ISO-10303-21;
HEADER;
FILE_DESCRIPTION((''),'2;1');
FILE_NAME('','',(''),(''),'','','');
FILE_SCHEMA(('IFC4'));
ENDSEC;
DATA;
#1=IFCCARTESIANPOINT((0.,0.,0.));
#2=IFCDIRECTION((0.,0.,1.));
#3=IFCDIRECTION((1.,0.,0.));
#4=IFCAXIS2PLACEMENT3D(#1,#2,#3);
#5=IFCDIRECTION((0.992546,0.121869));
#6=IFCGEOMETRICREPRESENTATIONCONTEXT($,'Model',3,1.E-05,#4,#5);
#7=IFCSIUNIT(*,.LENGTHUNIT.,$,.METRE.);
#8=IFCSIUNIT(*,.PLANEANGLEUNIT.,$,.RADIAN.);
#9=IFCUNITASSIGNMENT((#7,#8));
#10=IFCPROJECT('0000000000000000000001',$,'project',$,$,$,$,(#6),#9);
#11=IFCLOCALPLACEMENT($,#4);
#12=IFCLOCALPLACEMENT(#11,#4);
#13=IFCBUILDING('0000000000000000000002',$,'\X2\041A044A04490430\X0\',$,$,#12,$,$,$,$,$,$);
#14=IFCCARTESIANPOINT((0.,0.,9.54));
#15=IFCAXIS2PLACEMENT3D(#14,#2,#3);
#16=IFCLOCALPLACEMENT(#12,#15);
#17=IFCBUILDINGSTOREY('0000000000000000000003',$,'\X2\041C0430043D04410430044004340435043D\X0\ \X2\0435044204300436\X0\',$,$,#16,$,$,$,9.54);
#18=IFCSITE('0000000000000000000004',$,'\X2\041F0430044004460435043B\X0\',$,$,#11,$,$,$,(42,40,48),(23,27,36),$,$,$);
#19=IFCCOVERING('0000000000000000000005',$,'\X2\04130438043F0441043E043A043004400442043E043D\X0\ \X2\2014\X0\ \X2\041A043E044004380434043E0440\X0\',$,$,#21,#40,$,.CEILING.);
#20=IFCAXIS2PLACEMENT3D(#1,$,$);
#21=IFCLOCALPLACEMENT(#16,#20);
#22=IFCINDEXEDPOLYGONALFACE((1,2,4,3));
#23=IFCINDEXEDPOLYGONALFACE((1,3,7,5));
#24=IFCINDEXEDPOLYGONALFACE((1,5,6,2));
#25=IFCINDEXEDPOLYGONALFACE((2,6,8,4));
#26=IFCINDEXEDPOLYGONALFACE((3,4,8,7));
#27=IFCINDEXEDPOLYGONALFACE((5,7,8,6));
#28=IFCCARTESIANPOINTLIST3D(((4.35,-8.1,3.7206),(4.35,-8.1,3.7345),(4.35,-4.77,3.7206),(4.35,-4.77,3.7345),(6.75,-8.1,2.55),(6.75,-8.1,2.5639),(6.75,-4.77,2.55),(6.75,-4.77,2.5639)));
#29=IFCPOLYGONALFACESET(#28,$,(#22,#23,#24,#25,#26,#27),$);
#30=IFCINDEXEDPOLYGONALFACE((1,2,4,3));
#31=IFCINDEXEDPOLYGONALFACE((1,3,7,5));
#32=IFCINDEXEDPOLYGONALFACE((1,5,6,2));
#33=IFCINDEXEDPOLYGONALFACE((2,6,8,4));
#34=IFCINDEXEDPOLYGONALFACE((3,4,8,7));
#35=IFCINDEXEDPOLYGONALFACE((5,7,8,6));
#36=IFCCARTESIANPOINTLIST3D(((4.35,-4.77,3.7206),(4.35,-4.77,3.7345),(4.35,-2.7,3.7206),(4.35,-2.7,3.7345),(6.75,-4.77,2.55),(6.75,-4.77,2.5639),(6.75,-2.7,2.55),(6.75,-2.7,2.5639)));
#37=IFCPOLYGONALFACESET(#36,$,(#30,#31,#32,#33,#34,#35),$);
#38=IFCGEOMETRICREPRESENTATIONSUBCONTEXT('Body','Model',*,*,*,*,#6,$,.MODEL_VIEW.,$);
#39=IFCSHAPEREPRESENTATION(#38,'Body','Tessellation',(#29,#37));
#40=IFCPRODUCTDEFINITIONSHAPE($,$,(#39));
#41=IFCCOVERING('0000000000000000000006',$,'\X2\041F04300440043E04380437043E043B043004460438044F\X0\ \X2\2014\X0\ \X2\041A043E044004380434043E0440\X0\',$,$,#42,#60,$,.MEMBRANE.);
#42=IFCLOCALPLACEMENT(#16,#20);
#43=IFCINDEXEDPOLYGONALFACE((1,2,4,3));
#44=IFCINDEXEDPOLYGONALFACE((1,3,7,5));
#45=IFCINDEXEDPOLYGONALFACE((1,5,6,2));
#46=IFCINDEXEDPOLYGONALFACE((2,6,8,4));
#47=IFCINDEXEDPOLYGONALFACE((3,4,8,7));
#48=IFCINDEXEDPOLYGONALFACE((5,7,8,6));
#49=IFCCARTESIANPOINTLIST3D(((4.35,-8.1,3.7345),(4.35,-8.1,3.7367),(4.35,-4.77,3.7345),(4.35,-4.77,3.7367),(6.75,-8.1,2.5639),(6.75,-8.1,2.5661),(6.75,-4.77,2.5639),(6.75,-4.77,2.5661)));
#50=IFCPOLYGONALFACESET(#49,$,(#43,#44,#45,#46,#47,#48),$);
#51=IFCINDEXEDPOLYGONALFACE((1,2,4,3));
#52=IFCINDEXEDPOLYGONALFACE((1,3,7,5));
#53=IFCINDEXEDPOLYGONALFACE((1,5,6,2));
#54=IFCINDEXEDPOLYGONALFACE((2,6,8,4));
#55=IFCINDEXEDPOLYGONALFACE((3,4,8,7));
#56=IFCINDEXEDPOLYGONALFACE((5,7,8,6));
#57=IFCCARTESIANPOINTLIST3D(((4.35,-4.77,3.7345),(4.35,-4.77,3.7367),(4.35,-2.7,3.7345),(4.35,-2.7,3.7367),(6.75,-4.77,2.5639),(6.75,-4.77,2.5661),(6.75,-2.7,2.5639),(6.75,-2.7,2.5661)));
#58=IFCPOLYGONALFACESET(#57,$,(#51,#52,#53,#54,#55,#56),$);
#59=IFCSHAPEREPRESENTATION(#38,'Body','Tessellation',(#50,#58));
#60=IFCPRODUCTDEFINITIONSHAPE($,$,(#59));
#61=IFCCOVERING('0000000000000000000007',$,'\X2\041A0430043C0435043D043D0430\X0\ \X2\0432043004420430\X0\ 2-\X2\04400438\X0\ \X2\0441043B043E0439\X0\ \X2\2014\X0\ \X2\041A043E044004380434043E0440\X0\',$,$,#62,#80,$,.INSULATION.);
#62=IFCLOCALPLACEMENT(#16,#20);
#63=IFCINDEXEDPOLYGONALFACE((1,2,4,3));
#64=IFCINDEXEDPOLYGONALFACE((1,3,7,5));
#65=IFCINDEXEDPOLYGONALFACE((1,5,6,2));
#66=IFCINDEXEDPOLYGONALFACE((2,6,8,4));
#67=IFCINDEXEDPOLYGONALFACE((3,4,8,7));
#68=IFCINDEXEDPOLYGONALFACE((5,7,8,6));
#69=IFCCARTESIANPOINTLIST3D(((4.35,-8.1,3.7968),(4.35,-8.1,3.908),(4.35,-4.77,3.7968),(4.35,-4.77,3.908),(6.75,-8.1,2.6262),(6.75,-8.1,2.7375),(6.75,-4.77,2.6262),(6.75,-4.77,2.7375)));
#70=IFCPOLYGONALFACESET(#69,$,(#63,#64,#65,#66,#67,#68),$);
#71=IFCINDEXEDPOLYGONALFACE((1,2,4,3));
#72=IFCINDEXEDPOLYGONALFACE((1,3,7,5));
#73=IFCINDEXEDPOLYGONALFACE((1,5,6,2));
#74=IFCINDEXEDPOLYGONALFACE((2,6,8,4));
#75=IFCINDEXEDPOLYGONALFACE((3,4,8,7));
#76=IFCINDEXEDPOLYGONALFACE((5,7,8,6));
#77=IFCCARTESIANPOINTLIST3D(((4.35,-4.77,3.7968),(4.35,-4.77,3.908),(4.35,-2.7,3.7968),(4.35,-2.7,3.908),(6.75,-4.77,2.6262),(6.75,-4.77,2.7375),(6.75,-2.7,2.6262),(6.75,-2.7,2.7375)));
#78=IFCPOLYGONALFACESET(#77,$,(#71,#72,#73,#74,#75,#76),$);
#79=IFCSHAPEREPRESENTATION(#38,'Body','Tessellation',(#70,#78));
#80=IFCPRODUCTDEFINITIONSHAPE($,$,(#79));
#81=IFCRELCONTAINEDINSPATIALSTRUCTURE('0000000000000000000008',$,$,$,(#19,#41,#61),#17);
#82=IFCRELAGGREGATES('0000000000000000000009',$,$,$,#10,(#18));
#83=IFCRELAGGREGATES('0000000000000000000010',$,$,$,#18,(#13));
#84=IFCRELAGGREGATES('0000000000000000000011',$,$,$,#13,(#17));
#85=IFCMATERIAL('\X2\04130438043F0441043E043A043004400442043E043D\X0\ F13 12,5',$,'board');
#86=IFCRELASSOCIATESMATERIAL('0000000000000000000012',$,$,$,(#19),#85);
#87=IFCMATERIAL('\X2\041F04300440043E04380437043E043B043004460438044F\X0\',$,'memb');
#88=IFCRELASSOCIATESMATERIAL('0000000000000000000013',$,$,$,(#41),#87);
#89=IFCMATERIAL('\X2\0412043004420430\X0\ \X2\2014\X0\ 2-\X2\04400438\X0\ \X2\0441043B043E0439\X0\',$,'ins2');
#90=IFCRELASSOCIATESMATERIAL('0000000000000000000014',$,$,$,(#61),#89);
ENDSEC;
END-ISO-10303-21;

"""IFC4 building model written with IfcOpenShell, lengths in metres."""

from ifc_helpers import new_model, si_unit, direction, frame, origin_with_axes, place, context, subcontext, project, spatial, polyline, outline, extrude, material, element, save


model = new_model("IFC4")

# Units and contexts
model_context = context("Model", 3, precision=1e-05, world=origin_with_axes(), true_north=direction((0.992546, 0.121869)))
body_context = subcontext(model_context, "Body", "Model", "MODEL_VIEW")
ifc_project = project(units=[si_unit("LENGTHUNIT", "METRE"), si_unit("PLANEANGLEUNIT", "RADIAN")], contexts=[model_context])

# Site, building, storey
site_placement = place(None, origin_with_axes())
site = spatial("IfcSite", under=ifc_project, at=site_placement, Name="Парцел", RefLatitude=(42, 40, 48), RefLongitude=(23, 27, 36))
building_placement = place(site_placement, origin_with_axes())
building = spatial("IfcBuilding", under=site, at=building_placement, Name="Къща")
storey_placement = place(building_placement, frame((0.0, 0.0, 9.54), z_axis=(0.0, 0.0, 1.0), x_axis=(1.0, 0.0, 0.0)))
storey = spatial("IfcBuildingStorey", under=building, at=storey_placement, Name="Мансарден етаж", Elevation=9.54)

# Coverings
ifc_material_1 = material(Name="Гипсокартон F13 12,5", Category="board")
covering_1_placement = place(storey_placement, origin_with_axes())
element("IfcCovering", 1, at=covering_1_placement, inside=storey, material=ifc_material_1, Name="Гипсокартон — Коридор", PredefinedType="CEILING", context=body_context, shape_type="SweptSolid", body=[
    extrude(outline(polyline([(6.75, -2.55), (4.35, -3.7206), (4.35, -3.7345), (6.75, -2.5639), (6.75, -2.55)])), frame((0.0, -8.1, 0.0), z_axis=(0.0, 1.0, 0.0), x_axis=(1.0, 0.0, 0.0)), (0.0, 0.0, 1.0), 3.33),
    extrude(outline(polyline([(6.75, -2.55), (4.35, -3.7206), (4.35, -3.7345), (6.75, -2.5639), (6.75, -2.55)])), frame((0.0, -4.77, 0.0), z_axis=(0.0, 1.0, 0.0), x_axis=(1.0, 0.0, 0.0)), (0.0, 0.0, 1.0), 2.07),
])
ifc_material_2 = material(Name="Пароизолация", Category="memb")
covering_2_placement = place(storey_placement, origin_with_axes())
element("IfcCovering", 2, at=covering_2_placement, inside=storey, material=ifc_material_2, Name="Пароизолация — Коридор", PredefinedType="MEMBRANE", context=body_context, shape_type="SweptSolid", body=[
    extrude(outline(polyline([(6.75, -2.5639), (4.35, -3.7345), (4.35, -3.7367), (6.75, -2.5661), (6.75, -2.5639)])), frame((0.0, -8.1, 0.0), z_axis=(0.0, 1.0, 0.0), x_axis=(1.0, 0.0, 0.0)), (0.0, 0.0, 1.0), 3.33),
    extrude(outline(polyline([(6.75, -2.5639), (4.35, -3.7345), (4.35, -3.7367), (6.75, -2.5661), (6.75, -2.5639)])), frame((0.0, -4.77, 0.0), z_axis=(0.0, 1.0, 0.0), x_axis=(1.0, 0.0, 0.0)), (0.0, 0.0, 1.0), 2.07),
])
ifc_material_3 = material(Name="Вата — 2-ри слой", Category="ins2")
covering_3_placement = place(storey_placement, origin_with_axes())
element("IfcCovering", 3, at=covering_3_placement, inside=storey, material=ifc_material_3, Name="Каменна вата 2-ри слой — Коридор", PredefinedType="INSULATION", context=body_context, shape_type="SweptSolid", body=[
    extrude(outline(polyline([(6.75, -2.6262), (4.35, -3.7968), (4.35, -3.908), (6.75, -2.7375), (6.75, -2.6262)])), frame((0.0, -8.1, 0.0), z_axis=(0.0, 1.0, 0.0), x_axis=(1.0, 0.0, 0.0)), (0.0, 0.0, 1.0), 3.33),
    extrude(outline(polyline([(6.75, -2.6262), (4.35, -3.7968), (4.35, -3.908), (6.75, -2.7375), (6.75, -2.6262)])), frame((0.0, -4.77, 0.0), z_axis=(0.0, 1.0, 0.0), x_axis=(1.0, 0.0, 0.0)), (0.0, 0.0, 1.0), 2.07),
])

save(model, "model.ifc")
